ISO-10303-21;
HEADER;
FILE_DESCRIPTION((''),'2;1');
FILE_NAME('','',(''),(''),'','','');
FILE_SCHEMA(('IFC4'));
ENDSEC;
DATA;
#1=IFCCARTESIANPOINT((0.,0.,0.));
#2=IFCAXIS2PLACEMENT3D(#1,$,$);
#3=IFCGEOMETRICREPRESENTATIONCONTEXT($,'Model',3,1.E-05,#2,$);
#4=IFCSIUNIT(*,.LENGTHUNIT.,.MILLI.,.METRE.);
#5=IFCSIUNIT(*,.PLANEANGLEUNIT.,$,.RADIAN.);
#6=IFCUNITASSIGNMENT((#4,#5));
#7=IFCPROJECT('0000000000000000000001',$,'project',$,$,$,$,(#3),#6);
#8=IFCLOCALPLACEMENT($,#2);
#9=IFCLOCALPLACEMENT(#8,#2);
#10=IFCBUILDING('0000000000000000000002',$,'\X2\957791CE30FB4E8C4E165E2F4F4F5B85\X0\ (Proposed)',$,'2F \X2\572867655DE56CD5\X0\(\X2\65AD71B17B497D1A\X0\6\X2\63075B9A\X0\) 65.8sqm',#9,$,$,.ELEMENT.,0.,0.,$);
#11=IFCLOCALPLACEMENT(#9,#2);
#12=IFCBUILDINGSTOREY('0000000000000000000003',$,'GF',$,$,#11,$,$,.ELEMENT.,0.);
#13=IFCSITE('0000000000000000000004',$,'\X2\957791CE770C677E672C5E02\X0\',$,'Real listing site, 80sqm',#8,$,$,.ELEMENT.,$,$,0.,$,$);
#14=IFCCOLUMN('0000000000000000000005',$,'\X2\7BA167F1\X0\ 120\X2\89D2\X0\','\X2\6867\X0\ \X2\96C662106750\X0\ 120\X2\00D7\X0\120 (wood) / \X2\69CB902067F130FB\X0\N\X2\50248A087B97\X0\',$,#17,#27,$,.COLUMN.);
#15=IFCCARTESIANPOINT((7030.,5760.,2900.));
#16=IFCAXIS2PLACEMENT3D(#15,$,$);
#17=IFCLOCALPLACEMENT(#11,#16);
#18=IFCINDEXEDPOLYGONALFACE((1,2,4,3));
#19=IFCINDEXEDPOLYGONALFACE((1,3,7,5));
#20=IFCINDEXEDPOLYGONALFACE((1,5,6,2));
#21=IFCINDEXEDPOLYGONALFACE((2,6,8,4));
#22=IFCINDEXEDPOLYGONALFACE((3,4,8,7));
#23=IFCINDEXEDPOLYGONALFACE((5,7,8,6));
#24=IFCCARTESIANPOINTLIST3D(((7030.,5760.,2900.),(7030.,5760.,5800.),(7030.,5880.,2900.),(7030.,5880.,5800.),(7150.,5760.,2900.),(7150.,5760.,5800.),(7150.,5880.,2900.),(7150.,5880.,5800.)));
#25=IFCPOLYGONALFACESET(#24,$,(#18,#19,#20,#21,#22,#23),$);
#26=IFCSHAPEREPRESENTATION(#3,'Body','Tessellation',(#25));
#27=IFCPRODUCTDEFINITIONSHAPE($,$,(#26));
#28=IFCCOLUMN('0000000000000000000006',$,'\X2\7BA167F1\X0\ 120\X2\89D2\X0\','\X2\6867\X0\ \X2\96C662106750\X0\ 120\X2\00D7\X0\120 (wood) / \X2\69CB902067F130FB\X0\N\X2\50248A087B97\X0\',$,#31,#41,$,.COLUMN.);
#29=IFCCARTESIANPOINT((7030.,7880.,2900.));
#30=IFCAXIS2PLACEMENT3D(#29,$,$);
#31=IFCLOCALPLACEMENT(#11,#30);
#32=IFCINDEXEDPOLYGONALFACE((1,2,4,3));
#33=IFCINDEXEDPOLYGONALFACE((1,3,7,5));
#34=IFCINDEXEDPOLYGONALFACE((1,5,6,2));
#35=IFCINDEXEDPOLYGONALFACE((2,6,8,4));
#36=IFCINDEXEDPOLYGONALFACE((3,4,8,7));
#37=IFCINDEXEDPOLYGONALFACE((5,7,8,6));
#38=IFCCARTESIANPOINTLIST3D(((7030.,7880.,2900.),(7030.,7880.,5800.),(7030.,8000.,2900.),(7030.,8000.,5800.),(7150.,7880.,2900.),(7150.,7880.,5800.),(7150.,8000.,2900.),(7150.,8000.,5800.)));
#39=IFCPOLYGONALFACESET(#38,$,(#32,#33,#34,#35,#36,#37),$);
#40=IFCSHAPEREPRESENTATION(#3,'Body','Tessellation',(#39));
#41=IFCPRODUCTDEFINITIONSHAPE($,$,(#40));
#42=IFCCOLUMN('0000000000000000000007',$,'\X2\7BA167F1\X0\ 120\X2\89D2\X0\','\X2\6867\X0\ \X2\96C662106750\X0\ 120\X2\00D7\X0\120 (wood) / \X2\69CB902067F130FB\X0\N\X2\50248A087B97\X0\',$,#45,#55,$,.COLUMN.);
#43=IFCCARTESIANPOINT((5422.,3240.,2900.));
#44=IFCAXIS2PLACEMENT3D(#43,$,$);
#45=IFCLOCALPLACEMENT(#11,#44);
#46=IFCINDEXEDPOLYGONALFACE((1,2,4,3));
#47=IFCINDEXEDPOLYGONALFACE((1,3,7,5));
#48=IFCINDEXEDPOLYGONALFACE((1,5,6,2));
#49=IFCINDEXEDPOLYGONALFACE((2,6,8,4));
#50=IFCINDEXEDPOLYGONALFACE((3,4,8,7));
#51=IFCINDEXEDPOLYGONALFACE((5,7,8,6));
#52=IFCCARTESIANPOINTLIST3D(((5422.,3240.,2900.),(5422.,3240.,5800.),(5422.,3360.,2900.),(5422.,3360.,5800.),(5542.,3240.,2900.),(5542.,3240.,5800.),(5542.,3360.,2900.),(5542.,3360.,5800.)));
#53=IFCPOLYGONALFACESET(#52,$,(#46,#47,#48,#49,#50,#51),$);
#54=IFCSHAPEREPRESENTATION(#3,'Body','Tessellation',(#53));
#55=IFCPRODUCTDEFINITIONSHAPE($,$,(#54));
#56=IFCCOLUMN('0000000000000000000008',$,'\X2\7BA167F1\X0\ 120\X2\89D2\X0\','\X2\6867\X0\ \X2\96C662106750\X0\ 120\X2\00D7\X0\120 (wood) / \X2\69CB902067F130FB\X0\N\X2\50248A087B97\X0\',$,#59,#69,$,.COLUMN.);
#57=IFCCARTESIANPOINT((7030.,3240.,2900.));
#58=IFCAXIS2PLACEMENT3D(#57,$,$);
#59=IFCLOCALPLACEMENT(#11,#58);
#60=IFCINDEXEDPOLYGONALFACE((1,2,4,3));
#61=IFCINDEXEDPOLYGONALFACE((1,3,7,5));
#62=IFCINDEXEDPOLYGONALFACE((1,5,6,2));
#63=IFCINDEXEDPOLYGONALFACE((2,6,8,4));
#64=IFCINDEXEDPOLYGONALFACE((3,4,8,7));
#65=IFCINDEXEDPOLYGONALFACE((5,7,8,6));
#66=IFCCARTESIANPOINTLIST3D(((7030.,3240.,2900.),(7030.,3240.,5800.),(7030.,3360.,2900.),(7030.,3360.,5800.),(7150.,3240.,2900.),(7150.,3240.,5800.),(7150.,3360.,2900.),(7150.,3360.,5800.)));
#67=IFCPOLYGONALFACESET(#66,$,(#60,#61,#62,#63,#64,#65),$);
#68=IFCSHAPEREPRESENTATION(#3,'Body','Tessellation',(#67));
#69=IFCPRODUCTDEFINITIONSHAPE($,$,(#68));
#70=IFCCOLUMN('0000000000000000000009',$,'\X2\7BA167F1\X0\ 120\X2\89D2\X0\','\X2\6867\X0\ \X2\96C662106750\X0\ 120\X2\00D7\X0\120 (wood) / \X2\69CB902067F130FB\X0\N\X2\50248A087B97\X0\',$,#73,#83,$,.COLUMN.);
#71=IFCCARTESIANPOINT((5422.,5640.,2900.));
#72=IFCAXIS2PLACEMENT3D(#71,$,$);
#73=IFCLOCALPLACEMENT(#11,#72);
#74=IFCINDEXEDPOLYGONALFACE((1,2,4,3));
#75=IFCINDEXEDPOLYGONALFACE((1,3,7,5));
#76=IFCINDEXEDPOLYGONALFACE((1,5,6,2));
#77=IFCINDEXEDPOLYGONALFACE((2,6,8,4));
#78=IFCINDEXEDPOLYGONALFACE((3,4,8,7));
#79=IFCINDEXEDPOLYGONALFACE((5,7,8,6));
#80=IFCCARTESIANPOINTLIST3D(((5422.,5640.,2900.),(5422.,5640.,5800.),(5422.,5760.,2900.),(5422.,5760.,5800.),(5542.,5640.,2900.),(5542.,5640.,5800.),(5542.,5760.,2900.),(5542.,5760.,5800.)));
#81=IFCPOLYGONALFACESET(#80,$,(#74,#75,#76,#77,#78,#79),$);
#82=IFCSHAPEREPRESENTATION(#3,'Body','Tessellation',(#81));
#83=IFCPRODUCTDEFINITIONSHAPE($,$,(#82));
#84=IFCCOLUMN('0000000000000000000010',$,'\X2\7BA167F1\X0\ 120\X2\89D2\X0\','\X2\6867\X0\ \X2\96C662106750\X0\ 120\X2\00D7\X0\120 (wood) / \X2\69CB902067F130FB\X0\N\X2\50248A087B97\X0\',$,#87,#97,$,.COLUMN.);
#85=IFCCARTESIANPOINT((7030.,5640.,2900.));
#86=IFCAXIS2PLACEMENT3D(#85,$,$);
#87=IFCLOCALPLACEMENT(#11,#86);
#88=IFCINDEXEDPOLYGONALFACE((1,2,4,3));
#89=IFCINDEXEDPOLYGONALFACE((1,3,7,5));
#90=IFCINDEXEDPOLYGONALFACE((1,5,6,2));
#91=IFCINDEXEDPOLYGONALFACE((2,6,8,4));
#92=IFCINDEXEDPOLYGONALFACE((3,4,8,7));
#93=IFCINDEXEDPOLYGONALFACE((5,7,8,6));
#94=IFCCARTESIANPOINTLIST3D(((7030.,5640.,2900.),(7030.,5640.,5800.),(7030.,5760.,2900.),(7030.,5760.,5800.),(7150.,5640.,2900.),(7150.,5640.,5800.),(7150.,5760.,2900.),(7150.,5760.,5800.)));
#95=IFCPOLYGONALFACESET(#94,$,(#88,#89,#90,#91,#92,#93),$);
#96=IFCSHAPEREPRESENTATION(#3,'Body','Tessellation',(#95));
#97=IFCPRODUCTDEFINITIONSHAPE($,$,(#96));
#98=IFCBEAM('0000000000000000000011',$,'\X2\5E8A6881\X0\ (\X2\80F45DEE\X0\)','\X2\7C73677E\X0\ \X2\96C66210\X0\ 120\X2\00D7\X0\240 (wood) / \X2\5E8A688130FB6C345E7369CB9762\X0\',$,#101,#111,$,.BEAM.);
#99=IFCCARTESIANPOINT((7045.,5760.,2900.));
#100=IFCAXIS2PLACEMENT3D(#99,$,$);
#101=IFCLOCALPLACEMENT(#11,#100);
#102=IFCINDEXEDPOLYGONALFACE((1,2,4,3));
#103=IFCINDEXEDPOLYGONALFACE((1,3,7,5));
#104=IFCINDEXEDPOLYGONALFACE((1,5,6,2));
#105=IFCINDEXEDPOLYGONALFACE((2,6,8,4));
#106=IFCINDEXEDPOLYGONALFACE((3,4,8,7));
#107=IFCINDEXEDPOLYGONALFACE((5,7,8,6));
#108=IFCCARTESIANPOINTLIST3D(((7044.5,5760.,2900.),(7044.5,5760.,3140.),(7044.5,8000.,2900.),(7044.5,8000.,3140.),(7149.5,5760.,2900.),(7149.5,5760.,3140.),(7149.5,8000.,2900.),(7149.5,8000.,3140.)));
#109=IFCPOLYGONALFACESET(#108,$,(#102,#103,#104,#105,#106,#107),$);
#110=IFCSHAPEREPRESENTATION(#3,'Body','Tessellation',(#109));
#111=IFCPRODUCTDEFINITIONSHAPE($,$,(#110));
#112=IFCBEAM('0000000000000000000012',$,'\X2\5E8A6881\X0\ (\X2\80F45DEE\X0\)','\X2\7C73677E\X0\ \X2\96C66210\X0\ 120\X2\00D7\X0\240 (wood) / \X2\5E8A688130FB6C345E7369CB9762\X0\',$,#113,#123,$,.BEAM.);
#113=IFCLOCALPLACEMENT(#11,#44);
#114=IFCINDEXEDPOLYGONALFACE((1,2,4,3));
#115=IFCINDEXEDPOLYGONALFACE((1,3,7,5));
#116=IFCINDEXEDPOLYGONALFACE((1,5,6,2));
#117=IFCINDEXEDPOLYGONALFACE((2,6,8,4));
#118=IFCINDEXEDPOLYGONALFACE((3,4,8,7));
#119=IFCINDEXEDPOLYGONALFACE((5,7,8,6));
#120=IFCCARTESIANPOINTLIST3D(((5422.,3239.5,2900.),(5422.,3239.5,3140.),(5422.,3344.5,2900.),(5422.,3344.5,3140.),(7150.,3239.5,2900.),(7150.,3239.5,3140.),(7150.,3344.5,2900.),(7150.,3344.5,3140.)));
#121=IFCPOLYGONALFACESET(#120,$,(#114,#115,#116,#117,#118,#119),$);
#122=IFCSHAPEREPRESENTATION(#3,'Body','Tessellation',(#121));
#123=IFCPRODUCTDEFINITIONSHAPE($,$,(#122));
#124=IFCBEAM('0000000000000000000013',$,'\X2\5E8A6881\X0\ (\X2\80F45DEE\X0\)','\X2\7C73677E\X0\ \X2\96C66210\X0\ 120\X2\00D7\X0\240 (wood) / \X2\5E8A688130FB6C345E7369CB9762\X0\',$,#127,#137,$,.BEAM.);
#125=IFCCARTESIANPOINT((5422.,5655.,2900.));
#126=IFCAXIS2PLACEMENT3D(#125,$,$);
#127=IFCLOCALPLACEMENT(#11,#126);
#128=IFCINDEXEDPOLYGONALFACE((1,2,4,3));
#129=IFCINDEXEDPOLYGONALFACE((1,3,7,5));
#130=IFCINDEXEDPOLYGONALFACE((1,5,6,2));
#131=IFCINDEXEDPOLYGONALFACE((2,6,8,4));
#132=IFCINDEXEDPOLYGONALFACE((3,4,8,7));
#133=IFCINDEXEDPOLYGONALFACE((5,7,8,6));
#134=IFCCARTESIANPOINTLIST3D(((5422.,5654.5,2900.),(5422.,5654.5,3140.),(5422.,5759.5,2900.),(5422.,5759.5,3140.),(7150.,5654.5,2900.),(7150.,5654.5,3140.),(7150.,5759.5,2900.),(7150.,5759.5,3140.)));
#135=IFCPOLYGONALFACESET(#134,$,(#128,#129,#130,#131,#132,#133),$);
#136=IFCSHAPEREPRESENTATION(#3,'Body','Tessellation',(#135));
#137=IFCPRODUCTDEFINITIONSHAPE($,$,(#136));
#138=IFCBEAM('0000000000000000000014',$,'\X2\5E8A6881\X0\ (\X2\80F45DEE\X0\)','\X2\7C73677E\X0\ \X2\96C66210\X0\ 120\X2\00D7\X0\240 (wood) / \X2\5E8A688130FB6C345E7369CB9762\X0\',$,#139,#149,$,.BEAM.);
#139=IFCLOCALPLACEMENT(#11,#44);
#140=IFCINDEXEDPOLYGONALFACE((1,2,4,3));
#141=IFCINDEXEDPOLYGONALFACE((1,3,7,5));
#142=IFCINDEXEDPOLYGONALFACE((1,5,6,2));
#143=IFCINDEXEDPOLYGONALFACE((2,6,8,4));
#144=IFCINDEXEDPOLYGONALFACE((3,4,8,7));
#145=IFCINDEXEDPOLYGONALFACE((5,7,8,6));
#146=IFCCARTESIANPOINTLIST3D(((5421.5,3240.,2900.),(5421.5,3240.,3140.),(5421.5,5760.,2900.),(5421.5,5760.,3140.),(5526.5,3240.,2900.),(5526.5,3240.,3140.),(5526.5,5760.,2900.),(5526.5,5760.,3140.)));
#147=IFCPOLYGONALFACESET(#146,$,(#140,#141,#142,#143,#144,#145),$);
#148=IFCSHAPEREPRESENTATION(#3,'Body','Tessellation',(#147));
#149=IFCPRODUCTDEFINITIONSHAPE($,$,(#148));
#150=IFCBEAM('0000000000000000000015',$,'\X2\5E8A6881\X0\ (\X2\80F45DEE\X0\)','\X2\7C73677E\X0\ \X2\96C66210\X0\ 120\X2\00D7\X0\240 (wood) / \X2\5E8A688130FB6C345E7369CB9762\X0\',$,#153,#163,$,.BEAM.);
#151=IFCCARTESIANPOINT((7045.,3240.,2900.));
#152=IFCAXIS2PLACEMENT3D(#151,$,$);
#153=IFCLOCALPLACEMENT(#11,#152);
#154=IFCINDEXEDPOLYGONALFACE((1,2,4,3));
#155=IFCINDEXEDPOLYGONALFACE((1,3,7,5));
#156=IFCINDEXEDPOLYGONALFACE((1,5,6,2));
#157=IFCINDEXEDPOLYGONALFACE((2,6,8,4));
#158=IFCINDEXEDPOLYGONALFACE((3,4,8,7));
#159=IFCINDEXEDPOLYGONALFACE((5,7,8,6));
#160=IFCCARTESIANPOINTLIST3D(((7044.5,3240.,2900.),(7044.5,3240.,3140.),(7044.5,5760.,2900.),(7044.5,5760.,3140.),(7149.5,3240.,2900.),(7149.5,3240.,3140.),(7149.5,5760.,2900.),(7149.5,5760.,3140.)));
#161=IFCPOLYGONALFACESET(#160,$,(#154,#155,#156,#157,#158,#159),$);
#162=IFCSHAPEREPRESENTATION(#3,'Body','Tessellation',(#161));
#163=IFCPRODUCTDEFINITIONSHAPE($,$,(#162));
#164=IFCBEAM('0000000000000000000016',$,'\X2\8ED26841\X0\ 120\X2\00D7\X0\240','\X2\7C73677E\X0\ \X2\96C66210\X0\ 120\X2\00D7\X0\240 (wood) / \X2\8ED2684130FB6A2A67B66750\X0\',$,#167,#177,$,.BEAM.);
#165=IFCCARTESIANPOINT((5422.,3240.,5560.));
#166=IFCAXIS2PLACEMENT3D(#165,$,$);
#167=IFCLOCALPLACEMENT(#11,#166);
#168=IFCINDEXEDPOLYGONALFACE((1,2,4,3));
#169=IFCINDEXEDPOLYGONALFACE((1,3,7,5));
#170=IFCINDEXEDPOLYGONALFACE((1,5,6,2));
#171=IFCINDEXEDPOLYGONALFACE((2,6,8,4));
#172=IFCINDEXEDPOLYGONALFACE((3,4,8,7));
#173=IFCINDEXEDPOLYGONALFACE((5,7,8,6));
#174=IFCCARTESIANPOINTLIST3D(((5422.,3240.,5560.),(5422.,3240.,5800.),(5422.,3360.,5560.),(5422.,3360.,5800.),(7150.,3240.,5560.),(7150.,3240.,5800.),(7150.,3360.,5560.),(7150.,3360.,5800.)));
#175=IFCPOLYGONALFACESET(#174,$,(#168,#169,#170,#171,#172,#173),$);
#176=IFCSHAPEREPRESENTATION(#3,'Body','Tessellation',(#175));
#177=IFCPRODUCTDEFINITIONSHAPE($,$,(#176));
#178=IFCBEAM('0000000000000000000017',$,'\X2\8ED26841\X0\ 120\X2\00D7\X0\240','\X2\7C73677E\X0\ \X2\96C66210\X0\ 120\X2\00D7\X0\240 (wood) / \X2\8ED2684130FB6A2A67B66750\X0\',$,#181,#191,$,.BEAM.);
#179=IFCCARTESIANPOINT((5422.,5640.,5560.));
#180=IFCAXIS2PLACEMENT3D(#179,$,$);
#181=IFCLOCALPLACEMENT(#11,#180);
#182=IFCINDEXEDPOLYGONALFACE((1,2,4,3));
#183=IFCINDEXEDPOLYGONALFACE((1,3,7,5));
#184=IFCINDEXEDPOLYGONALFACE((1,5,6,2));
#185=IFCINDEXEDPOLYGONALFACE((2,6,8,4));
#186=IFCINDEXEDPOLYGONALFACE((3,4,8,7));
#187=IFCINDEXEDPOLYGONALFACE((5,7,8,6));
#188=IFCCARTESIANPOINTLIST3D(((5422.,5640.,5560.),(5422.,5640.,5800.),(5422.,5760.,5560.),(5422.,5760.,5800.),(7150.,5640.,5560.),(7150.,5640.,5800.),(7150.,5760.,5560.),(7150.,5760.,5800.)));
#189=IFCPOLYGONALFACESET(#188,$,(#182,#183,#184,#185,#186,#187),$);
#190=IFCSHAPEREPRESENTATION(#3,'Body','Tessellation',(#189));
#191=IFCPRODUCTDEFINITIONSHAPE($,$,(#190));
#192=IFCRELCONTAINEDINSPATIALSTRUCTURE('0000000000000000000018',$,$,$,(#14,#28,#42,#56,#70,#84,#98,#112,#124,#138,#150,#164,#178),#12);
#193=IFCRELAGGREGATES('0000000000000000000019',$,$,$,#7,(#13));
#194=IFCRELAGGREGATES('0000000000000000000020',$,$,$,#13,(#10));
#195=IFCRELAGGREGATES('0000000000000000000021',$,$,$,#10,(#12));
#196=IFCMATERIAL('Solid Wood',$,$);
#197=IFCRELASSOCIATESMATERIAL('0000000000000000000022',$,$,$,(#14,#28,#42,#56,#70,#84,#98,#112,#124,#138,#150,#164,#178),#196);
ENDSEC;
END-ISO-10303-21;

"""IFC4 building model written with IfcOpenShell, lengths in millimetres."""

from ifc_helpers import new_model, si_unit, frame, frame_2d, origin, place, context, project, spatial, rectangle, extrude, material, element, save


model = new_model("IFC4")

# Units and contexts
model_context = context("Model", 3, precision=1e-05, world=origin())
ifc_project = project(units=[si_unit("LENGTHUNIT", "METRE", prefix="MILLI"), si_unit("PLANEANGLEUNIT", "RADIAN")], contexts=[model_context])

# Site, building, storey
site_placement = place(None, origin())
site = spatial("IfcSite", under=ifc_project, at=site_placement, Name="長野県松本市", ObjectType="Real listing site, 80sqm", CompositionType="ELEMENT", RefElevation=0.0)
building_placement = place(site_placement, origin())
building = spatial("IfcBuilding", under=site, at=building_placement, Name="長野・二世帯住宅 (Proposed)", ObjectType="2F 在来工法(断熱等級6指定) 65.8sqm", CompositionType="ELEMENT", ElevationOfRefHeight=0.0, ElevationOfTerrain=0.0)
storey_placement = place(building_placement, origin())
storey = spatial("IfcBuildingStorey", under=building, at=storey_placement, Name="GF", CompositionType="ELEMENT", Elevation=0.0)

# Columns
ifc_material_1 = material(Name="Solid Wood")
column_1_placement = place(storey_placement, frame((7030.0, 5760.0, 2900.0)))
element("IfcColumn", 1, at=column_1_placement, inside=storey, material=ifc_material_1, Name="管柱 120角", Description="桧 集成材 120×120 (wood) / 構造柱・N値計算", PredefinedType="COLUMN", context=model_context, shape_type="SweptSolid", body=[
    extrude(rectangle(XDim=120.0, YDim=120.0, at=frame_2d((60.0, 60.0))), frame((7030.0, 5760.0, 2900.0)), (0.0, 0.0, 1.0), 2900.0),
])
column_2_placement = place(storey_placement, frame((7030.0, 7880.0, 2900.0)))
element("IfcColumn", 2, at=column_2_placement, inside=storey, material=ifc_material_1, Name="管柱 120角", Description="桧 集成材 120×120 (wood) / 構造柱・N値計算", PredefinedType="COLUMN", context=model_context, shape_type="SweptSolid", body=[
    extrude(rectangle(XDim=120.0, YDim=120.0, at=frame_2d((60.0, 60.0))), frame((7030.0, 7880.0, 2900.0)), (0.0, 0.0, 1.0), 2900.0),
])
column_3_placement = place(storey_placement, frame((5422.0, 3240.0, 2900.0)))
element("IfcColumn", 3, at=column_3_placement, inside=storey, material=ifc_material_1, Name="管柱 120角", Description="桧 集成材 120×120 (wood) / 構造柱・N値計算", PredefinedType="COLUMN", context=model_context, shape_type="SweptSolid", body=[
    extrude(rectangle(XDim=120.0, YDim=120.0, at=frame_2d((60.0, 60.0))), frame((5422.0, 3240.0, 2900.0)), (0.0, 0.0, 1.0), 2900.0),
])
column_4_placement = place(storey_placement, frame((7030.0, 3240.0, 2900.0)))
element("IfcColumn", 4, at=column_4_placement, inside=storey, material=ifc_material_1, Name="管柱 120角", Description="桧 集成材 120×120 (wood) / 構造柱・N値計算", PredefinedType="COLUMN", context=model_context, shape_type="SweptSolid", body=[
    extrude(rectangle(XDim=120.0, YDim=120.0, at=frame_2d((60.0, 60.0))), frame((7030.0, 3240.0, 2900.0)), (0.0, 0.0, 1.0), 2900.0),
])
column_5_placement = place(storey_placement, frame((5422.0, 5640.0, 2900.0)))
element("IfcColumn", 5, at=column_5_placement, inside=storey, material=ifc_material_1, Name="管柱 120角", Description="桧 集成材 120×120 (wood) / 構造柱・N値計算", PredefinedType="COLUMN", context=model_context, shape_type="SweptSolid", body=[
    extrude(rectangle(XDim=120.0, YDim=120.0, at=frame_2d((60.0, 60.0))), frame((5422.0, 5640.0, 2900.0)), (0.0, 0.0, 1.0), 2900.0),
])
column_6_placement = place(storey_placement, frame((7030.0, 5640.0, 2900.0)))
element("IfcColumn", 6, at=column_6_placement, inside=storey, material=ifc_material_1, Name="管柱 120角", Description="桧 集成材 120×120 (wood) / 構造柱・N値計算", PredefinedType="COLUMN", context=model_context, shape_type="SweptSolid", body=[
    extrude(rectangle(XDim=120.0, YDim=120.0, at=frame_2d((60.0, 60.0))), frame((7030.0, 5640.0, 2900.0)), (0.0, 0.0, 1.0), 2900.0),
])

# Beams
beam_1_placement = place(storey_placement, frame((7045.0, 5760.0, 2900.0)))
element("IfcBeam", 7, at=beam_1_placement, inside=storey, material=ifc_material_1, Name="床梁 (胴差)", Description="米松 集成 120×240 (wood) / 床梁・水平構面", PredefinedType="BEAM", context=model_context, shape_type="SweptSolid", body=[
    extrude(rectangle(XDim=105.0, YDim=2240.0, at=frame_2d((52.0, 1120.0))), frame((7045.0, 5760.0, 2900.0)), (0.0, 0.0, 1.0), 240.0),
])
beam_2_placement = place(storey_placement, frame((5422.0, 3240.0, 2900.0)))
element("IfcBeam", 8, at=beam_2_placement, inside=storey, material=ifc_material_1, Name="床梁 (胴差)", Description="米松 集成 120×240 (wood) / 床梁・水平構面", PredefinedType="BEAM", context=model_context, shape_type="SweptSolid", body=[
    extrude(rectangle(XDim=1728.0, YDim=105.0, at=frame_2d((864.0, 52.0))), frame((5422.0, 3240.0, 2900.0)), (0.0, 0.0, 1.0), 240.0),
])
beam_3_placement = place(storey_placement, frame((5422.0, 5655.0, 2900.0)))
element("IfcBeam", 9, at=beam_3_placement, inside=storey, material=ifc_material_1, Name="床梁 (胴差)", Description="米松 集成 120×240 (wood) / 床梁・水平構面", PredefinedType="BEAM", context=model_context, shape_type="SweptSolid", body=[
    extrude(rectangle(XDim=1728.0, YDim=105.0, at=frame_2d((864.0, 52.0))), frame((5422.0, 5655.0, 2900.0)), (0.0, 0.0, 1.0), 240.0),
])
beam_4_placement = place(storey_placement, frame((5422.0, 3240.0, 2900.0)))
element("IfcBeam", 10, at=beam_4_placement, inside=storey, material=ifc_material_1, Name="床梁 (胴差)", Description="米松 集成 120×240 (wood) / 床梁・水平構面", PredefinedType="BEAM", context=model_context, shape_type="SweptSolid", body=[
    extrude(rectangle(XDim=105.0, YDim=2520.0, at=frame_2d((52.0, 1260.0))), frame((5422.0, 3240.0, 2900.0)), (0.0, 0.0, 1.0), 240.0),
])
beam_5_placement = place(storey_placement, frame((7045.0, 3240.0, 2900.0)))
element("IfcBeam", 11, at=beam_5_placement, inside=storey, material=ifc_material_1, Name="床梁 (胴差)", Description="米松 集成 120×240 (wood) / 床梁・水平構面", PredefinedType="BEAM", context=model_context, shape_type="SweptSolid", body=[
    extrude(rectangle(XDim=105.0, YDim=2520.0, at=frame_2d((52.0, 1260.0))), frame((7045.0, 3240.0, 2900.0)), (0.0, 0.0, 1.0), 240.0),
])
beam_6_placement = place(storey_placement, frame((5422.0, 3240.0, 5560.0)))
element("IfcBeam", 12, at=beam_6_placement, inside=storey, material=ifc_material_1, Name="軒桁 120×240", Description="米松 集成 120×240 (wood) / 軒桁・横架材", PredefinedType="BEAM", context=model_context, shape_type="SweptSolid", body=[
    extrude(rectangle(XDim=1728.0, YDim=120.0, at=frame_2d((864.0, 60.0))), frame((5422.0, 3240.0, 5560.0)), (0.0, 0.0, 1.0), 240.0),
])
beam_7_placement = place(storey_placement, frame((5422.0, 5640.0, 5560.0)))
element("IfcBeam", 13, at=beam_7_placement, inside=storey, material=ifc_material_1, Name="軒桁 120×240", Description="米松 集成 120×240 (wood) / 軒桁・横架材", PredefinedType="BEAM", context=model_context, shape_type="SweptSolid", body=[
    extrude(rectangle(XDim=1728.0, YDim=120.0, at=frame_2d((864.0, 60.0))), frame((5422.0, 5640.0, 5560.0)), (0.0, 0.0, 1.0), 240.0),
])

save(model, "model.ifc")
